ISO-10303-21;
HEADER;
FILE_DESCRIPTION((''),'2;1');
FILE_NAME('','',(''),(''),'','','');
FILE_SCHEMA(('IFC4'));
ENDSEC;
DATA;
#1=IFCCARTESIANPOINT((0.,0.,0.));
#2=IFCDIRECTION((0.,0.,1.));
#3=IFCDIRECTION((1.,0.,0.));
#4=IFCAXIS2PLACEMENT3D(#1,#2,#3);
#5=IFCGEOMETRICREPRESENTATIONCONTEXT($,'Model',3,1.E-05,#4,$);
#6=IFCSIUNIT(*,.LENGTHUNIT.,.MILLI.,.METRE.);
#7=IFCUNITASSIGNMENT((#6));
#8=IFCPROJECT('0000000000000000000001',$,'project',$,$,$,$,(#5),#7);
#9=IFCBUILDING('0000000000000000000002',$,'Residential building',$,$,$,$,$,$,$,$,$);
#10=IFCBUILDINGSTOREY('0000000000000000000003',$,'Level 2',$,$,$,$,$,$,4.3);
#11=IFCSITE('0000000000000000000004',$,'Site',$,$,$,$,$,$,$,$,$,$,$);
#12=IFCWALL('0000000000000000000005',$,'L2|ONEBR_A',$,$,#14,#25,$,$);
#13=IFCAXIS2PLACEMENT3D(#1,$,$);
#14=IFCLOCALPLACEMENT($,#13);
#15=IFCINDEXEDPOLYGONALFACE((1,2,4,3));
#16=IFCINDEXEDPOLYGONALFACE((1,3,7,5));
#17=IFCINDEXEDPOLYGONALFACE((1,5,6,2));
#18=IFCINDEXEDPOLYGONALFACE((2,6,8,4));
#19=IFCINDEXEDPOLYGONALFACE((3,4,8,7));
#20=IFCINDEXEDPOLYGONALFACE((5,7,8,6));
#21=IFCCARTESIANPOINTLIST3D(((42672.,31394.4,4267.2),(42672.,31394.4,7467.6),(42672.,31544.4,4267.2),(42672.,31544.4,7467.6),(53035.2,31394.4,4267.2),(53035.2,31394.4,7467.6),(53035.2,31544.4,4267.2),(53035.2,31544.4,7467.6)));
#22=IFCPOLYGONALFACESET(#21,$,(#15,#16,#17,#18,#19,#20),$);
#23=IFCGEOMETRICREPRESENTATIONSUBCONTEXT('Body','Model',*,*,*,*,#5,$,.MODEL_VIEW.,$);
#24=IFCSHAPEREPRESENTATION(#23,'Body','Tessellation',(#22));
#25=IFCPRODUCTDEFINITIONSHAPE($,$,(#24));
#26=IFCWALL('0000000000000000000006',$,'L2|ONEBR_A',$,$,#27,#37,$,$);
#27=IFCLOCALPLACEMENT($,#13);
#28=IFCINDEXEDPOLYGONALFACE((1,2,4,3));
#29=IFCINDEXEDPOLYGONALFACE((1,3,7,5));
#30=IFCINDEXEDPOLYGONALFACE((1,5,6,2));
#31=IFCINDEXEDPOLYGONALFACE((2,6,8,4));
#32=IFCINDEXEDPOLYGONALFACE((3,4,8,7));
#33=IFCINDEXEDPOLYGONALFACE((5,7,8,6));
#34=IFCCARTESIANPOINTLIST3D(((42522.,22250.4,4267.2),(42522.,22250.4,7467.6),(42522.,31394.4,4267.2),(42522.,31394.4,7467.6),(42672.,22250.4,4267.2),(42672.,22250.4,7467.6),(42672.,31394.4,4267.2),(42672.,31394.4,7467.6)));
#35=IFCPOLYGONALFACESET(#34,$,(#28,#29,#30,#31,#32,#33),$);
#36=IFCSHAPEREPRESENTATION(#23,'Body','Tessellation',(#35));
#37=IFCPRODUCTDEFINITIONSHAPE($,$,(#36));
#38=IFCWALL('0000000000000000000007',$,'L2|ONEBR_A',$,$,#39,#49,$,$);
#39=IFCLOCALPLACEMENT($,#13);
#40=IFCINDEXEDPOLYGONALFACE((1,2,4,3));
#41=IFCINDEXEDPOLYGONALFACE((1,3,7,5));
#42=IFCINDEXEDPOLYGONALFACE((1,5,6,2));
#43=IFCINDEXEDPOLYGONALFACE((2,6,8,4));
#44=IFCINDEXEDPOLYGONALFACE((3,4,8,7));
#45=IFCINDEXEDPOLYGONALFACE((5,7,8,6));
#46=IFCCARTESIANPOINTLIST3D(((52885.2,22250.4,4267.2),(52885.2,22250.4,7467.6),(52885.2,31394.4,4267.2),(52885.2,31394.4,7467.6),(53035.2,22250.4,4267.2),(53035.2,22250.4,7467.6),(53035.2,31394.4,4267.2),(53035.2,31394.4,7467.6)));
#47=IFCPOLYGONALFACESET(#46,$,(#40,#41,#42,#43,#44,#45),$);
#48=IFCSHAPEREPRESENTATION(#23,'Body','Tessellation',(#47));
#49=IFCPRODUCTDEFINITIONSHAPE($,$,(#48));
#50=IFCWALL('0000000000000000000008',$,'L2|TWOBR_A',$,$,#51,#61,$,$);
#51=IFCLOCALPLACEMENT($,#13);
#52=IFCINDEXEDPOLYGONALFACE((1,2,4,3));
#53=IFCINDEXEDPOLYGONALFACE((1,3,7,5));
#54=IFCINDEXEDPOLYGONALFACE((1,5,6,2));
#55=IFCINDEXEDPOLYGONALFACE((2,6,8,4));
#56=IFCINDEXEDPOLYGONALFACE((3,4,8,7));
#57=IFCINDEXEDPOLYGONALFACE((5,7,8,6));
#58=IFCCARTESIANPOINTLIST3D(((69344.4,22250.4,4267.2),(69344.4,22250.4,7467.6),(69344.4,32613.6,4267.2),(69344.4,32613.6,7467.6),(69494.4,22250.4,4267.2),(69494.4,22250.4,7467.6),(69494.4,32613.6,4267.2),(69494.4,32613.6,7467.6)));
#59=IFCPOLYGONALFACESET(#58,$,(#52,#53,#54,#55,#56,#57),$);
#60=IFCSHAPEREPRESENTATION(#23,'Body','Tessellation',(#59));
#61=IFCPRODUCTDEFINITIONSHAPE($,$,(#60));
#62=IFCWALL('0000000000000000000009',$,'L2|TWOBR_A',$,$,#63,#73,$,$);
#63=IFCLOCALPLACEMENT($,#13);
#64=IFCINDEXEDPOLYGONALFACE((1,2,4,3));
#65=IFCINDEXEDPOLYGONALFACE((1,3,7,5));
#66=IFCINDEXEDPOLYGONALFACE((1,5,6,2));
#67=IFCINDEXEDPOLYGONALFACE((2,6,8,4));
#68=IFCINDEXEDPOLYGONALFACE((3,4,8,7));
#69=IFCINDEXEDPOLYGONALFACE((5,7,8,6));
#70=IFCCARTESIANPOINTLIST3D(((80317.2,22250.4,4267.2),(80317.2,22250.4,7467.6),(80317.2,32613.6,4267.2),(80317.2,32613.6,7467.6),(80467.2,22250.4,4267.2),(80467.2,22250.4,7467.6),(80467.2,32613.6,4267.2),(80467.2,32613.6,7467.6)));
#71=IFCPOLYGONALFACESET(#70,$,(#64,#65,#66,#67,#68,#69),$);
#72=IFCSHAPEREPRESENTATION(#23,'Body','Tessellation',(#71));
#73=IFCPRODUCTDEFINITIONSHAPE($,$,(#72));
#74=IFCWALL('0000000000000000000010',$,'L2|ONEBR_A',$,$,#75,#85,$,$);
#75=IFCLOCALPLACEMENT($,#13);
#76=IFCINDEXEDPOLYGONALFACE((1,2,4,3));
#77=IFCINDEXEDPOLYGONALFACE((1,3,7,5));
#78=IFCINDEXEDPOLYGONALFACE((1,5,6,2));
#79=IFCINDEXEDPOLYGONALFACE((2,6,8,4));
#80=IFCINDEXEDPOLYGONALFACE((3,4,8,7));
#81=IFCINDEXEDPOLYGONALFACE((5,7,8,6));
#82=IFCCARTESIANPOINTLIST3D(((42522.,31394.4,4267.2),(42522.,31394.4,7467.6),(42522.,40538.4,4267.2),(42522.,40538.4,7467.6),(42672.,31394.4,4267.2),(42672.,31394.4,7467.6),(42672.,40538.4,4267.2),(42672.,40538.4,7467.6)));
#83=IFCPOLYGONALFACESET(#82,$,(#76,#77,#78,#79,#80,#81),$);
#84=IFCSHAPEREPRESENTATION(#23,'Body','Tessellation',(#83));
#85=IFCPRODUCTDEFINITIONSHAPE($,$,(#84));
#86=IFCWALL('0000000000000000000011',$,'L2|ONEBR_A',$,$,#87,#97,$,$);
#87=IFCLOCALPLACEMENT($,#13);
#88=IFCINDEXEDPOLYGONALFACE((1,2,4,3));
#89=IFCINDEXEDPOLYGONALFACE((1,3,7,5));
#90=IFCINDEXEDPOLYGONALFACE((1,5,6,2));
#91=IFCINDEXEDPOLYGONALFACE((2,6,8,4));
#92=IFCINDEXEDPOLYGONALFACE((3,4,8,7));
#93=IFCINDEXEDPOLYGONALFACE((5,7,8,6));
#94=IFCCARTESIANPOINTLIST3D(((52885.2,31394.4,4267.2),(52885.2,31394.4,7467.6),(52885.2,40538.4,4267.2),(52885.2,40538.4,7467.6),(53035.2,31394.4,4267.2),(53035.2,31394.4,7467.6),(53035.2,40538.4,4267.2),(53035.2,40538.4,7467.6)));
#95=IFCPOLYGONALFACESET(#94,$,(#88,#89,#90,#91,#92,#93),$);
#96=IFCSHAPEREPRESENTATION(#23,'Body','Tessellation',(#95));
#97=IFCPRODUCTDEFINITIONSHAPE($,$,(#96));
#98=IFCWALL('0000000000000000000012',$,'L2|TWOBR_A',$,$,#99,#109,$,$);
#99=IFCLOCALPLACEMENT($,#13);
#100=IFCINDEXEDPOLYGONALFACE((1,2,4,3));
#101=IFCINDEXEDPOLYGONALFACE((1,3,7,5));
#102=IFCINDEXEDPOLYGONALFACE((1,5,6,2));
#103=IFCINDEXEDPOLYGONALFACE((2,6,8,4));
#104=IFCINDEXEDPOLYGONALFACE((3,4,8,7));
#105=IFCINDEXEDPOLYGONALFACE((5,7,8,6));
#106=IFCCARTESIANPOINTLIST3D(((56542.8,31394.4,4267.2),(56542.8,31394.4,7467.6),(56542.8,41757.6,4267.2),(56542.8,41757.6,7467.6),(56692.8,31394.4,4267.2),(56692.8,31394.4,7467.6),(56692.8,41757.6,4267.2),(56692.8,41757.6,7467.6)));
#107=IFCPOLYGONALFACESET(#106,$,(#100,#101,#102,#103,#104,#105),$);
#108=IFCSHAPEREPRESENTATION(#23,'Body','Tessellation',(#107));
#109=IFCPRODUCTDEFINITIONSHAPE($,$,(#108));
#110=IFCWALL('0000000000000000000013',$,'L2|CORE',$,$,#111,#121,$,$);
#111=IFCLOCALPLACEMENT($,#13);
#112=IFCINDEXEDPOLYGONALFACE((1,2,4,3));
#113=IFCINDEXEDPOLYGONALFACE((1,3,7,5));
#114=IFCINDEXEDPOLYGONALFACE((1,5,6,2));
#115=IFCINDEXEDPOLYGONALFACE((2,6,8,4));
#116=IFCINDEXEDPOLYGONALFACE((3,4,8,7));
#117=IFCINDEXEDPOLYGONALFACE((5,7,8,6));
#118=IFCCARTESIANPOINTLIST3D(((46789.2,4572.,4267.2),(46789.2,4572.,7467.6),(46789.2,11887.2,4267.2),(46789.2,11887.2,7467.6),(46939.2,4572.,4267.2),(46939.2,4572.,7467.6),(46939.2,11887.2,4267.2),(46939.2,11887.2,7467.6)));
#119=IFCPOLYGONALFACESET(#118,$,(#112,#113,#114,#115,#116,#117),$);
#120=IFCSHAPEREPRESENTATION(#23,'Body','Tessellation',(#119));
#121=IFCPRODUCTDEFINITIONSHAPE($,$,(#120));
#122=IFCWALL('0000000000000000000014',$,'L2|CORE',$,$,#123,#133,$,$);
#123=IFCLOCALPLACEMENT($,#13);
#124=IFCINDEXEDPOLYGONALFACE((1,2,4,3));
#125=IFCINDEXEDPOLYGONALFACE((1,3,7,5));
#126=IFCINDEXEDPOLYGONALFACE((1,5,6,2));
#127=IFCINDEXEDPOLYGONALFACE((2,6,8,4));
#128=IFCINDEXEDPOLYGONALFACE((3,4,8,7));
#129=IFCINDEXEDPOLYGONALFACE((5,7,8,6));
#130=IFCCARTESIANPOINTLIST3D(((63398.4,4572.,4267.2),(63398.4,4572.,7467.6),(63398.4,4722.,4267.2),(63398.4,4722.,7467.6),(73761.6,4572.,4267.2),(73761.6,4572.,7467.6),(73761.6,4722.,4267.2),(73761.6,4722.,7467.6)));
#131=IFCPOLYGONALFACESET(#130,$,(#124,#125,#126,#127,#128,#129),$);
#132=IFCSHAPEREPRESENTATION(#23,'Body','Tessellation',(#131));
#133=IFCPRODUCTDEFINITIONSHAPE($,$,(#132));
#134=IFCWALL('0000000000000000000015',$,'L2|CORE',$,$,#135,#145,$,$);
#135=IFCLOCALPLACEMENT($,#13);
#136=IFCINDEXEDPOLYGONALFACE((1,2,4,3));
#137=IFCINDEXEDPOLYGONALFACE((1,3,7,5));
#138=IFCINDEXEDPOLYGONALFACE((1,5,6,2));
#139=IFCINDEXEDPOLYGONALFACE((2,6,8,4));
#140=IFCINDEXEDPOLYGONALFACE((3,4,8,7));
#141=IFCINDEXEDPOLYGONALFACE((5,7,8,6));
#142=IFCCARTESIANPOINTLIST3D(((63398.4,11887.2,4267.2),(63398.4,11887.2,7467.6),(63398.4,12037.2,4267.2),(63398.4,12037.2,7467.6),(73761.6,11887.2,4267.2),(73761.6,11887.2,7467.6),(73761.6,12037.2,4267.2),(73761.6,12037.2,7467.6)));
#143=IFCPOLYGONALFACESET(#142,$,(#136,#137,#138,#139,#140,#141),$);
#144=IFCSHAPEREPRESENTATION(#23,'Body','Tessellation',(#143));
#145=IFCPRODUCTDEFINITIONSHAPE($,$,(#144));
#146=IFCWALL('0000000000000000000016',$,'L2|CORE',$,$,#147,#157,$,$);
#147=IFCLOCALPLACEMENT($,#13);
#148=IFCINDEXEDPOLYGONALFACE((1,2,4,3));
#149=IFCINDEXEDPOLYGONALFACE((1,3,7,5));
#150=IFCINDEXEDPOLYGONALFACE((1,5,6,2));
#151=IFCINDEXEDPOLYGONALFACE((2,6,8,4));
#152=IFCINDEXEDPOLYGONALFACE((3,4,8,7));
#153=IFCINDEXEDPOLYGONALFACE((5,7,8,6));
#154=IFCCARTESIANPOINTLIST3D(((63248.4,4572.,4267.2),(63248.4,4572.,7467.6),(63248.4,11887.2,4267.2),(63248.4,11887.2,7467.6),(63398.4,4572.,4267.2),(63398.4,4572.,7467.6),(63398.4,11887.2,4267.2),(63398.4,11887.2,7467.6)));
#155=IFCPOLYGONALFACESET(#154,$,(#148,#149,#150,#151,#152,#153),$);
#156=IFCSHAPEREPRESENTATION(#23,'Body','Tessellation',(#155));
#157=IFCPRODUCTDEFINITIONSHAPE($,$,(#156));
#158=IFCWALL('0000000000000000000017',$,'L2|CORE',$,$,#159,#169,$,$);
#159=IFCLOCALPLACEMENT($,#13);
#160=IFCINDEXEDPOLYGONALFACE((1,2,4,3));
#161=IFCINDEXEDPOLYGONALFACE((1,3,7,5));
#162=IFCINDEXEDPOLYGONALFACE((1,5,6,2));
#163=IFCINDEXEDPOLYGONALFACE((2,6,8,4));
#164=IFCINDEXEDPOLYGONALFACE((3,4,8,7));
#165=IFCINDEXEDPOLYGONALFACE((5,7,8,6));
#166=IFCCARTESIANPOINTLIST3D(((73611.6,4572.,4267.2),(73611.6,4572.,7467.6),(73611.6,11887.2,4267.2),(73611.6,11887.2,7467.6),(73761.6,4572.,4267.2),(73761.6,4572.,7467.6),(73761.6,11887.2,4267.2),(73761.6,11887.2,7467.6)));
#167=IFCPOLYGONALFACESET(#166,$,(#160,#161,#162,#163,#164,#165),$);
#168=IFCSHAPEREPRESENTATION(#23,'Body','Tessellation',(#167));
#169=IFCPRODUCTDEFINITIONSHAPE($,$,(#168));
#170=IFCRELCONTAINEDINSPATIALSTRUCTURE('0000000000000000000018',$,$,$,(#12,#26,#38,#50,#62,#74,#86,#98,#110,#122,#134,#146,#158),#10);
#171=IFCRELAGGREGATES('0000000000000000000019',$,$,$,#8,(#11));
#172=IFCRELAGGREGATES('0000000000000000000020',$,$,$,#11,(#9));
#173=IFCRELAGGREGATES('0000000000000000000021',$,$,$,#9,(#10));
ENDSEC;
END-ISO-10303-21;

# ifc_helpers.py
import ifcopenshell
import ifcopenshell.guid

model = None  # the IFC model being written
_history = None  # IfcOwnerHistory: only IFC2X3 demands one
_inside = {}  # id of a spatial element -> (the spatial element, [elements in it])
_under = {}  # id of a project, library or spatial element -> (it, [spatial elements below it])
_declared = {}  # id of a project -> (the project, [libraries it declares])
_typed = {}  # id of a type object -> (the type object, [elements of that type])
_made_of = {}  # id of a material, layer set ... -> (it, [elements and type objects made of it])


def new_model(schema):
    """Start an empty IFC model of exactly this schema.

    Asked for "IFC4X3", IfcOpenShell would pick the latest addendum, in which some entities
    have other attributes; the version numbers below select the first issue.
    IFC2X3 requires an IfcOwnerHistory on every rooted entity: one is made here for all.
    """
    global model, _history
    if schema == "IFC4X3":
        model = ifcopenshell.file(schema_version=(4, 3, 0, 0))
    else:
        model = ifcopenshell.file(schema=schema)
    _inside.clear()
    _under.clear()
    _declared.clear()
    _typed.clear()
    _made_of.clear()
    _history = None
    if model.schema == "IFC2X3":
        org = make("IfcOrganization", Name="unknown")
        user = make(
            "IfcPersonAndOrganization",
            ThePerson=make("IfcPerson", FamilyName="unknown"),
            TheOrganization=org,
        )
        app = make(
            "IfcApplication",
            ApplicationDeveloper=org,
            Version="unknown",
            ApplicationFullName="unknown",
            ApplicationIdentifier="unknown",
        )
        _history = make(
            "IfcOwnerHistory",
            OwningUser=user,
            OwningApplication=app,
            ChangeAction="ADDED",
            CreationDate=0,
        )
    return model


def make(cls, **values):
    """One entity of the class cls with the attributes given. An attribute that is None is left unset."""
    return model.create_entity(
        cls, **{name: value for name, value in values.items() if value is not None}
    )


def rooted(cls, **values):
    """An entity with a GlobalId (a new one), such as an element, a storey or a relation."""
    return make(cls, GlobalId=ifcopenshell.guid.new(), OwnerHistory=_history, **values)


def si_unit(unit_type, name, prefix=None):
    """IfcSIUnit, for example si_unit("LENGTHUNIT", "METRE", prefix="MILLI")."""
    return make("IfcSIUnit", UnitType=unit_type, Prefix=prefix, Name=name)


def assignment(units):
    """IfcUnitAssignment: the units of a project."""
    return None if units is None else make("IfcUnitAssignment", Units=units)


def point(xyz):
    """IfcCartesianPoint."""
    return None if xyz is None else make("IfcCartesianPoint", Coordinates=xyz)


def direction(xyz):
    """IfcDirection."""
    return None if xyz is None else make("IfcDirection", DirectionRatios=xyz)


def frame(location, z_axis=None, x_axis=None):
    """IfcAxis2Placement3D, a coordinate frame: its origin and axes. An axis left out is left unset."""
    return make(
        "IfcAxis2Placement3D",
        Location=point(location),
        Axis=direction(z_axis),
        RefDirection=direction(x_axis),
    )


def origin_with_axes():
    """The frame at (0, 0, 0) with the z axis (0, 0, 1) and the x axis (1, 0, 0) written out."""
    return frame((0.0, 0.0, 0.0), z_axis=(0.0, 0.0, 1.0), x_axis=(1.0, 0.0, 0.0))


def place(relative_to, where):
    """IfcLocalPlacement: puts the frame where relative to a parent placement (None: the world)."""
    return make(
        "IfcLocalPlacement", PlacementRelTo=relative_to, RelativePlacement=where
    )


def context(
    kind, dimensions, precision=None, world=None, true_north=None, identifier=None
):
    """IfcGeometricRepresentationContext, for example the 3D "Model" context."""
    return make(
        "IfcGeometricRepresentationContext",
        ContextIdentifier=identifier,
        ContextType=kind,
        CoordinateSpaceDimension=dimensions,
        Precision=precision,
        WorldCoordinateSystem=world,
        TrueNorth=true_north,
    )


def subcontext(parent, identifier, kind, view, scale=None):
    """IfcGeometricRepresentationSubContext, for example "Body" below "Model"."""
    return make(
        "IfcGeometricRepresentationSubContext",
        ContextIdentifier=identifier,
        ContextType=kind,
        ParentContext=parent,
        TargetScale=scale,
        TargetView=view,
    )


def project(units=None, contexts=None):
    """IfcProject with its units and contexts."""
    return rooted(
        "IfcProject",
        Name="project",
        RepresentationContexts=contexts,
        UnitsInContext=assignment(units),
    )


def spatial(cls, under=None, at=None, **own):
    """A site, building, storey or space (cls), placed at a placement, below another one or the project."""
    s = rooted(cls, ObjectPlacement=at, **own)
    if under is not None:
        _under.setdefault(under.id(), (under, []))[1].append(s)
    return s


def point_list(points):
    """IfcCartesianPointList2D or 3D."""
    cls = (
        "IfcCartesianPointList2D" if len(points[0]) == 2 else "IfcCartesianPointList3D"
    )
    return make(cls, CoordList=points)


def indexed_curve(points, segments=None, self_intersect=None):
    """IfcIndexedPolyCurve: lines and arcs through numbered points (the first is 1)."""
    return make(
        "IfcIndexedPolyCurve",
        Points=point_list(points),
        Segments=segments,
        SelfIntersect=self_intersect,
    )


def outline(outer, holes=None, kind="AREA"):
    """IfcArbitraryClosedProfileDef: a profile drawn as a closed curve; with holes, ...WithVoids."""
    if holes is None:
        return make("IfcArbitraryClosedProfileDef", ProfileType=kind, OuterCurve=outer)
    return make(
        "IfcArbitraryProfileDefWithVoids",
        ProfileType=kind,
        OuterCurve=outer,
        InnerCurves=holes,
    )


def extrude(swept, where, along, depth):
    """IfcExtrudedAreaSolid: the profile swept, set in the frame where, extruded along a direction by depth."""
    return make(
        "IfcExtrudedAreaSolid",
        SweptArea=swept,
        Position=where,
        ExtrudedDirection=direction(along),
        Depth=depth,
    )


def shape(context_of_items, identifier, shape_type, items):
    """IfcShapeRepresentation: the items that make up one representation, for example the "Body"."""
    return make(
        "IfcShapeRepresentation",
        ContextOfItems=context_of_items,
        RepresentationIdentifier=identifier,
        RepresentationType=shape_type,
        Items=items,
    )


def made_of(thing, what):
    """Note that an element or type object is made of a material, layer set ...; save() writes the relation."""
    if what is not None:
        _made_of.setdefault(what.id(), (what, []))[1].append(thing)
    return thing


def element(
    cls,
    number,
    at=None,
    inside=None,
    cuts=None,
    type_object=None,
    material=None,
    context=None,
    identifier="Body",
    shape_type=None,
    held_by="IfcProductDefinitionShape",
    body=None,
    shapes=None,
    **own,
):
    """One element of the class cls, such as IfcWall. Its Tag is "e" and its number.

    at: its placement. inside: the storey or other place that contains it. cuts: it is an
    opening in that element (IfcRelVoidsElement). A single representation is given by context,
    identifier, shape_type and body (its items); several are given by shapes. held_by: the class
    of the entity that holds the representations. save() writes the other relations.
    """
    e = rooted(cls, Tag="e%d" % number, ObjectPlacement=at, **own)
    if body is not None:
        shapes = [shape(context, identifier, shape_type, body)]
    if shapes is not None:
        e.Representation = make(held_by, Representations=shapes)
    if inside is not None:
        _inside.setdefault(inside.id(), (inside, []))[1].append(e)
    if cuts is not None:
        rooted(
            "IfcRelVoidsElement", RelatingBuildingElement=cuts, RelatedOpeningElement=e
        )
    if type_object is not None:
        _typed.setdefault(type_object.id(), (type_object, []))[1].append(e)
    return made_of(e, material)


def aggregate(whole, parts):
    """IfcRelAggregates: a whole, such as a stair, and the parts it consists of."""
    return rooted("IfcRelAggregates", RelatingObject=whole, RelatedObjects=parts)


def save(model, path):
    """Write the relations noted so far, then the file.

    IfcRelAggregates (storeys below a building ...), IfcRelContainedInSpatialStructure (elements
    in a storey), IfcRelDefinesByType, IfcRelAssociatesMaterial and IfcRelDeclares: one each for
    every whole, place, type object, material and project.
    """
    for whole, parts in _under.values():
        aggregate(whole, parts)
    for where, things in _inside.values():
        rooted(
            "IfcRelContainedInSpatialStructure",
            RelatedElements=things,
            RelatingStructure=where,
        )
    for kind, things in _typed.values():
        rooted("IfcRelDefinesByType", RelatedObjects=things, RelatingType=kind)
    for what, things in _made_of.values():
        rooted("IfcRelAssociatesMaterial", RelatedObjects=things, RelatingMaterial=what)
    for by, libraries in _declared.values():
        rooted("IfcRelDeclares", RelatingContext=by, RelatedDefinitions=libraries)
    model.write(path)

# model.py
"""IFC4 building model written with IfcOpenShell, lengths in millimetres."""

from ifc_helpers import new_model, si_unit, frame, origin_with_axes, place, context, subcontext, project, spatial, indexed_curve, outline, extrude, element, save


model = new_model("IFC4")

# Units and contexts
model_context = context("Model", 3, precision=1e-05, world=origin_with_axes())
body_context = subcontext(model_context, "Body", "Model", "MODEL_VIEW")
ifc_project = project(units=[si_unit("LENGTHUNIT", "METRE", prefix="MILLI")], contexts=[model_context])

# Site, building, storey
site = spatial("IfcSite", under=ifc_project, Name="Site")
building = spatial("IfcBuilding", under=site, Name="Residential building")
storey = spatial("IfcBuildingStorey", under=building, Name="Level 2", Elevation=4.3)

# Walls
for number, where, z_axis, x_axis, name in (
    (1, (42672.0, 31394.4, 4267.2), (0.0, 0.0, 1.0), (1.0, 0.0, 0.0), "L2|ONEBR_A"),
):
    element("IfcWall", number, at=place(None, frame(where, z_axis=z_axis, x_axis=x_axis)), inside=storey, Name=name, context=body_context, shape_type="SweptSolid", body=[
        extrude(outline(indexed_curve([(0.0, 0.0), (0.0, 150.0), (10363.2, 150.0), (10363.2, 0.0), (0.0, 0.0)], self_intersect=False)), origin_with_axes(), (0.0, 0.0, 1.0), 3200.4),
    ])
for number, where, z_axis, x_axis, name in (
    (2, (42672.0, 22250.4, 4267.2), (0.0, 0.0, 1.0), (0.0, 1.0, 0.0), "L2|ONEBR_A"),
    (3, (53035.2, 22250.4, 4267.2), (0.0, 0.0, 1.0), (0.0, 1.0, 0.0), "L2|ONEBR_A"),
):
    element("IfcWall", number, at=place(None, frame(where, z_axis=z_axis, x_axis=x_axis)), inside=storey, Name=name, context=body_context, shape_type="SweptSolid", body=[
        extrude(outline(indexed_curve([(0.0, 0.0), (0.0, 150.0), (9144.0, 150.0), (9144.0, 0.0), (0.0, 0.0)], self_intersect=False)), origin_with_axes(), (0.0, 0.0, 1.0), 3200.4),
    ])
for number, where, z_axis, x_axis, name in (
    (4, (69494.4, 22250.4, 4267.2), (0.0, 0.0, 1.0), (0.0, 1.0, 0.0), "L2|TWOBR_A"),
    (5, (80467.2, 22250.4, 4267.2), (0.0, 0.0, 1.0), (0.0, 1.0, 0.0), "L2|TWOBR_A"),
):
    element("IfcWall", number, at=place(None, frame(where, z_axis=z_axis, x_axis=x_axis)), inside=storey, Name=name, context=body_context, shape_type="SweptSolid", body=[
        extrude(outline(indexed_curve([(0.0, 0.0), (0.0, 150.0), (10363.2, 150.0), (10363.2, 0.0), (0.0, 0.0)], self_intersect=False)), origin_with_axes(), (0.0, 0.0, 1.0), 3200.4),
    ])
for number, where, z_axis, x_axis, name in (
    (6, (42672.0, 31394.4, 4267.2), (0.0, 0.0, 1.0), (0.0, 1.0, 0.0), "L2|ONEBR_A"),
    (7, (53035.2, 31394.4, 4267.2), (0.0, 0.0, 1.0), (0.0, 1.0, 0.0), "L2|ONEBR_A"),
):
    element("IfcWall", number, at=place(None, frame(where, z_axis=z_axis, x_axis=x_axis)), inside=storey, Name=name, context=body_context, shape_type="SweptSolid", body=[
        extrude(outline(indexed_curve([(0.0, 0.0), (0.0, 150.0), (9144.0, 150.0), (9144.0, 0.0), (0.0, 0.0)], self_intersect=False)), origin_with_axes(), (0.0, 0.0, 1.0), 3200.4),
    ])
wall_1_placement = place(None, frame((56692.8, 31394.4, 4267.2), z_axis=(0.0, 0.0, 1.0), x_axis=(0.0, 1.0, 0.0)))
element("IfcWall", 8, at=wall_1_placement, inside=storey, Name="L2|TWOBR_A", context=body_context, shape_type="SweptSolid", body=[
    extrude(outline(indexed_curve([(0.0, 0.0), (0.0, 150.0), (10363.2, 150.0), (10363.2, 0.0), (0.0, 0.0)], self_intersect=False)), origin_with_axes(), (0.0, 0.0, 1.0), 3200.4),
])
wall_2_placement = place(None, frame((46939.2, 4572.0, 4267.2), z_axis=(0.0, 0.0, 1.0), x_axis=(0.0, 1.0, 0.0)))
element("IfcWall", 9, at=wall_2_placement, inside=storey, Name="L2|CORE", context=body_context, shape_type="SweptSolid", body=[
    extrude(outline(indexed_curve([(0.0, 0.0), (0.0, 150.0), (7315.2, 150.0), (7315.2, 0.0), (0.0, 0.0)], self_intersect=False)), origin_with_axes(), (0.0, 0.0, 1.0), 3200.4),
])
for number, where, z_axis, x_axis, name in (
    (10, (63398.4, 4572.0, 4267.2), (0.0, 0.0, 1.0), (1.0, 0.0, 0.0), "L2|CORE"),
    (11, (63398.4, 11887.2, 4267.2), (0.0, 0.0, 1.0), (1.0, 0.0, 0.0), "L2|CORE"),
):
    element("IfcWall", number, at=place(None, frame(where, z_axis=z_axis, x_axis=x_axis)), inside=storey, Name=name, context=body_context, shape_type="SweptSolid", body=[
        extrude(outline(indexed_curve([(0.0, 0.0), (0.0, 150.0), (10363.2, 150.0), (10363.2, 0.0), (0.0, 0.0)], self_intersect=False)), origin_with_axes(), (0.0, 0.0, 1.0), 3200.4),
    ])
for number, where, z_axis, x_axis, name in (
    (12, (63398.4, 4572.0, 4267.2), (0.0, 0.0, 1.0), (0.0, 1.0, 0.0), "L2|CORE"),
    (13, (73761.6, 4572.0, 4267.2), (0.0, 0.0, 1.0), (0.0, 1.0, 0.0), "L2|CORE"),
):
    element("IfcWall", number, at=place(None, frame(where, z_axis=z_axis, x_axis=x_axis)), inside=storey, Name=name, context=body_context, shape_type="SweptSolid", body=[
        extrude(outline(indexed_curve([(0.0, 0.0), (0.0, 150.0), (7315.2, 150.0), (7315.2, 0.0), (0.0, 0.0)], self_intersect=False)), origin_with_axes(), (0.0, 0.0, 1.0), 3200.4),
    ])

save(model, "model.ifc")
